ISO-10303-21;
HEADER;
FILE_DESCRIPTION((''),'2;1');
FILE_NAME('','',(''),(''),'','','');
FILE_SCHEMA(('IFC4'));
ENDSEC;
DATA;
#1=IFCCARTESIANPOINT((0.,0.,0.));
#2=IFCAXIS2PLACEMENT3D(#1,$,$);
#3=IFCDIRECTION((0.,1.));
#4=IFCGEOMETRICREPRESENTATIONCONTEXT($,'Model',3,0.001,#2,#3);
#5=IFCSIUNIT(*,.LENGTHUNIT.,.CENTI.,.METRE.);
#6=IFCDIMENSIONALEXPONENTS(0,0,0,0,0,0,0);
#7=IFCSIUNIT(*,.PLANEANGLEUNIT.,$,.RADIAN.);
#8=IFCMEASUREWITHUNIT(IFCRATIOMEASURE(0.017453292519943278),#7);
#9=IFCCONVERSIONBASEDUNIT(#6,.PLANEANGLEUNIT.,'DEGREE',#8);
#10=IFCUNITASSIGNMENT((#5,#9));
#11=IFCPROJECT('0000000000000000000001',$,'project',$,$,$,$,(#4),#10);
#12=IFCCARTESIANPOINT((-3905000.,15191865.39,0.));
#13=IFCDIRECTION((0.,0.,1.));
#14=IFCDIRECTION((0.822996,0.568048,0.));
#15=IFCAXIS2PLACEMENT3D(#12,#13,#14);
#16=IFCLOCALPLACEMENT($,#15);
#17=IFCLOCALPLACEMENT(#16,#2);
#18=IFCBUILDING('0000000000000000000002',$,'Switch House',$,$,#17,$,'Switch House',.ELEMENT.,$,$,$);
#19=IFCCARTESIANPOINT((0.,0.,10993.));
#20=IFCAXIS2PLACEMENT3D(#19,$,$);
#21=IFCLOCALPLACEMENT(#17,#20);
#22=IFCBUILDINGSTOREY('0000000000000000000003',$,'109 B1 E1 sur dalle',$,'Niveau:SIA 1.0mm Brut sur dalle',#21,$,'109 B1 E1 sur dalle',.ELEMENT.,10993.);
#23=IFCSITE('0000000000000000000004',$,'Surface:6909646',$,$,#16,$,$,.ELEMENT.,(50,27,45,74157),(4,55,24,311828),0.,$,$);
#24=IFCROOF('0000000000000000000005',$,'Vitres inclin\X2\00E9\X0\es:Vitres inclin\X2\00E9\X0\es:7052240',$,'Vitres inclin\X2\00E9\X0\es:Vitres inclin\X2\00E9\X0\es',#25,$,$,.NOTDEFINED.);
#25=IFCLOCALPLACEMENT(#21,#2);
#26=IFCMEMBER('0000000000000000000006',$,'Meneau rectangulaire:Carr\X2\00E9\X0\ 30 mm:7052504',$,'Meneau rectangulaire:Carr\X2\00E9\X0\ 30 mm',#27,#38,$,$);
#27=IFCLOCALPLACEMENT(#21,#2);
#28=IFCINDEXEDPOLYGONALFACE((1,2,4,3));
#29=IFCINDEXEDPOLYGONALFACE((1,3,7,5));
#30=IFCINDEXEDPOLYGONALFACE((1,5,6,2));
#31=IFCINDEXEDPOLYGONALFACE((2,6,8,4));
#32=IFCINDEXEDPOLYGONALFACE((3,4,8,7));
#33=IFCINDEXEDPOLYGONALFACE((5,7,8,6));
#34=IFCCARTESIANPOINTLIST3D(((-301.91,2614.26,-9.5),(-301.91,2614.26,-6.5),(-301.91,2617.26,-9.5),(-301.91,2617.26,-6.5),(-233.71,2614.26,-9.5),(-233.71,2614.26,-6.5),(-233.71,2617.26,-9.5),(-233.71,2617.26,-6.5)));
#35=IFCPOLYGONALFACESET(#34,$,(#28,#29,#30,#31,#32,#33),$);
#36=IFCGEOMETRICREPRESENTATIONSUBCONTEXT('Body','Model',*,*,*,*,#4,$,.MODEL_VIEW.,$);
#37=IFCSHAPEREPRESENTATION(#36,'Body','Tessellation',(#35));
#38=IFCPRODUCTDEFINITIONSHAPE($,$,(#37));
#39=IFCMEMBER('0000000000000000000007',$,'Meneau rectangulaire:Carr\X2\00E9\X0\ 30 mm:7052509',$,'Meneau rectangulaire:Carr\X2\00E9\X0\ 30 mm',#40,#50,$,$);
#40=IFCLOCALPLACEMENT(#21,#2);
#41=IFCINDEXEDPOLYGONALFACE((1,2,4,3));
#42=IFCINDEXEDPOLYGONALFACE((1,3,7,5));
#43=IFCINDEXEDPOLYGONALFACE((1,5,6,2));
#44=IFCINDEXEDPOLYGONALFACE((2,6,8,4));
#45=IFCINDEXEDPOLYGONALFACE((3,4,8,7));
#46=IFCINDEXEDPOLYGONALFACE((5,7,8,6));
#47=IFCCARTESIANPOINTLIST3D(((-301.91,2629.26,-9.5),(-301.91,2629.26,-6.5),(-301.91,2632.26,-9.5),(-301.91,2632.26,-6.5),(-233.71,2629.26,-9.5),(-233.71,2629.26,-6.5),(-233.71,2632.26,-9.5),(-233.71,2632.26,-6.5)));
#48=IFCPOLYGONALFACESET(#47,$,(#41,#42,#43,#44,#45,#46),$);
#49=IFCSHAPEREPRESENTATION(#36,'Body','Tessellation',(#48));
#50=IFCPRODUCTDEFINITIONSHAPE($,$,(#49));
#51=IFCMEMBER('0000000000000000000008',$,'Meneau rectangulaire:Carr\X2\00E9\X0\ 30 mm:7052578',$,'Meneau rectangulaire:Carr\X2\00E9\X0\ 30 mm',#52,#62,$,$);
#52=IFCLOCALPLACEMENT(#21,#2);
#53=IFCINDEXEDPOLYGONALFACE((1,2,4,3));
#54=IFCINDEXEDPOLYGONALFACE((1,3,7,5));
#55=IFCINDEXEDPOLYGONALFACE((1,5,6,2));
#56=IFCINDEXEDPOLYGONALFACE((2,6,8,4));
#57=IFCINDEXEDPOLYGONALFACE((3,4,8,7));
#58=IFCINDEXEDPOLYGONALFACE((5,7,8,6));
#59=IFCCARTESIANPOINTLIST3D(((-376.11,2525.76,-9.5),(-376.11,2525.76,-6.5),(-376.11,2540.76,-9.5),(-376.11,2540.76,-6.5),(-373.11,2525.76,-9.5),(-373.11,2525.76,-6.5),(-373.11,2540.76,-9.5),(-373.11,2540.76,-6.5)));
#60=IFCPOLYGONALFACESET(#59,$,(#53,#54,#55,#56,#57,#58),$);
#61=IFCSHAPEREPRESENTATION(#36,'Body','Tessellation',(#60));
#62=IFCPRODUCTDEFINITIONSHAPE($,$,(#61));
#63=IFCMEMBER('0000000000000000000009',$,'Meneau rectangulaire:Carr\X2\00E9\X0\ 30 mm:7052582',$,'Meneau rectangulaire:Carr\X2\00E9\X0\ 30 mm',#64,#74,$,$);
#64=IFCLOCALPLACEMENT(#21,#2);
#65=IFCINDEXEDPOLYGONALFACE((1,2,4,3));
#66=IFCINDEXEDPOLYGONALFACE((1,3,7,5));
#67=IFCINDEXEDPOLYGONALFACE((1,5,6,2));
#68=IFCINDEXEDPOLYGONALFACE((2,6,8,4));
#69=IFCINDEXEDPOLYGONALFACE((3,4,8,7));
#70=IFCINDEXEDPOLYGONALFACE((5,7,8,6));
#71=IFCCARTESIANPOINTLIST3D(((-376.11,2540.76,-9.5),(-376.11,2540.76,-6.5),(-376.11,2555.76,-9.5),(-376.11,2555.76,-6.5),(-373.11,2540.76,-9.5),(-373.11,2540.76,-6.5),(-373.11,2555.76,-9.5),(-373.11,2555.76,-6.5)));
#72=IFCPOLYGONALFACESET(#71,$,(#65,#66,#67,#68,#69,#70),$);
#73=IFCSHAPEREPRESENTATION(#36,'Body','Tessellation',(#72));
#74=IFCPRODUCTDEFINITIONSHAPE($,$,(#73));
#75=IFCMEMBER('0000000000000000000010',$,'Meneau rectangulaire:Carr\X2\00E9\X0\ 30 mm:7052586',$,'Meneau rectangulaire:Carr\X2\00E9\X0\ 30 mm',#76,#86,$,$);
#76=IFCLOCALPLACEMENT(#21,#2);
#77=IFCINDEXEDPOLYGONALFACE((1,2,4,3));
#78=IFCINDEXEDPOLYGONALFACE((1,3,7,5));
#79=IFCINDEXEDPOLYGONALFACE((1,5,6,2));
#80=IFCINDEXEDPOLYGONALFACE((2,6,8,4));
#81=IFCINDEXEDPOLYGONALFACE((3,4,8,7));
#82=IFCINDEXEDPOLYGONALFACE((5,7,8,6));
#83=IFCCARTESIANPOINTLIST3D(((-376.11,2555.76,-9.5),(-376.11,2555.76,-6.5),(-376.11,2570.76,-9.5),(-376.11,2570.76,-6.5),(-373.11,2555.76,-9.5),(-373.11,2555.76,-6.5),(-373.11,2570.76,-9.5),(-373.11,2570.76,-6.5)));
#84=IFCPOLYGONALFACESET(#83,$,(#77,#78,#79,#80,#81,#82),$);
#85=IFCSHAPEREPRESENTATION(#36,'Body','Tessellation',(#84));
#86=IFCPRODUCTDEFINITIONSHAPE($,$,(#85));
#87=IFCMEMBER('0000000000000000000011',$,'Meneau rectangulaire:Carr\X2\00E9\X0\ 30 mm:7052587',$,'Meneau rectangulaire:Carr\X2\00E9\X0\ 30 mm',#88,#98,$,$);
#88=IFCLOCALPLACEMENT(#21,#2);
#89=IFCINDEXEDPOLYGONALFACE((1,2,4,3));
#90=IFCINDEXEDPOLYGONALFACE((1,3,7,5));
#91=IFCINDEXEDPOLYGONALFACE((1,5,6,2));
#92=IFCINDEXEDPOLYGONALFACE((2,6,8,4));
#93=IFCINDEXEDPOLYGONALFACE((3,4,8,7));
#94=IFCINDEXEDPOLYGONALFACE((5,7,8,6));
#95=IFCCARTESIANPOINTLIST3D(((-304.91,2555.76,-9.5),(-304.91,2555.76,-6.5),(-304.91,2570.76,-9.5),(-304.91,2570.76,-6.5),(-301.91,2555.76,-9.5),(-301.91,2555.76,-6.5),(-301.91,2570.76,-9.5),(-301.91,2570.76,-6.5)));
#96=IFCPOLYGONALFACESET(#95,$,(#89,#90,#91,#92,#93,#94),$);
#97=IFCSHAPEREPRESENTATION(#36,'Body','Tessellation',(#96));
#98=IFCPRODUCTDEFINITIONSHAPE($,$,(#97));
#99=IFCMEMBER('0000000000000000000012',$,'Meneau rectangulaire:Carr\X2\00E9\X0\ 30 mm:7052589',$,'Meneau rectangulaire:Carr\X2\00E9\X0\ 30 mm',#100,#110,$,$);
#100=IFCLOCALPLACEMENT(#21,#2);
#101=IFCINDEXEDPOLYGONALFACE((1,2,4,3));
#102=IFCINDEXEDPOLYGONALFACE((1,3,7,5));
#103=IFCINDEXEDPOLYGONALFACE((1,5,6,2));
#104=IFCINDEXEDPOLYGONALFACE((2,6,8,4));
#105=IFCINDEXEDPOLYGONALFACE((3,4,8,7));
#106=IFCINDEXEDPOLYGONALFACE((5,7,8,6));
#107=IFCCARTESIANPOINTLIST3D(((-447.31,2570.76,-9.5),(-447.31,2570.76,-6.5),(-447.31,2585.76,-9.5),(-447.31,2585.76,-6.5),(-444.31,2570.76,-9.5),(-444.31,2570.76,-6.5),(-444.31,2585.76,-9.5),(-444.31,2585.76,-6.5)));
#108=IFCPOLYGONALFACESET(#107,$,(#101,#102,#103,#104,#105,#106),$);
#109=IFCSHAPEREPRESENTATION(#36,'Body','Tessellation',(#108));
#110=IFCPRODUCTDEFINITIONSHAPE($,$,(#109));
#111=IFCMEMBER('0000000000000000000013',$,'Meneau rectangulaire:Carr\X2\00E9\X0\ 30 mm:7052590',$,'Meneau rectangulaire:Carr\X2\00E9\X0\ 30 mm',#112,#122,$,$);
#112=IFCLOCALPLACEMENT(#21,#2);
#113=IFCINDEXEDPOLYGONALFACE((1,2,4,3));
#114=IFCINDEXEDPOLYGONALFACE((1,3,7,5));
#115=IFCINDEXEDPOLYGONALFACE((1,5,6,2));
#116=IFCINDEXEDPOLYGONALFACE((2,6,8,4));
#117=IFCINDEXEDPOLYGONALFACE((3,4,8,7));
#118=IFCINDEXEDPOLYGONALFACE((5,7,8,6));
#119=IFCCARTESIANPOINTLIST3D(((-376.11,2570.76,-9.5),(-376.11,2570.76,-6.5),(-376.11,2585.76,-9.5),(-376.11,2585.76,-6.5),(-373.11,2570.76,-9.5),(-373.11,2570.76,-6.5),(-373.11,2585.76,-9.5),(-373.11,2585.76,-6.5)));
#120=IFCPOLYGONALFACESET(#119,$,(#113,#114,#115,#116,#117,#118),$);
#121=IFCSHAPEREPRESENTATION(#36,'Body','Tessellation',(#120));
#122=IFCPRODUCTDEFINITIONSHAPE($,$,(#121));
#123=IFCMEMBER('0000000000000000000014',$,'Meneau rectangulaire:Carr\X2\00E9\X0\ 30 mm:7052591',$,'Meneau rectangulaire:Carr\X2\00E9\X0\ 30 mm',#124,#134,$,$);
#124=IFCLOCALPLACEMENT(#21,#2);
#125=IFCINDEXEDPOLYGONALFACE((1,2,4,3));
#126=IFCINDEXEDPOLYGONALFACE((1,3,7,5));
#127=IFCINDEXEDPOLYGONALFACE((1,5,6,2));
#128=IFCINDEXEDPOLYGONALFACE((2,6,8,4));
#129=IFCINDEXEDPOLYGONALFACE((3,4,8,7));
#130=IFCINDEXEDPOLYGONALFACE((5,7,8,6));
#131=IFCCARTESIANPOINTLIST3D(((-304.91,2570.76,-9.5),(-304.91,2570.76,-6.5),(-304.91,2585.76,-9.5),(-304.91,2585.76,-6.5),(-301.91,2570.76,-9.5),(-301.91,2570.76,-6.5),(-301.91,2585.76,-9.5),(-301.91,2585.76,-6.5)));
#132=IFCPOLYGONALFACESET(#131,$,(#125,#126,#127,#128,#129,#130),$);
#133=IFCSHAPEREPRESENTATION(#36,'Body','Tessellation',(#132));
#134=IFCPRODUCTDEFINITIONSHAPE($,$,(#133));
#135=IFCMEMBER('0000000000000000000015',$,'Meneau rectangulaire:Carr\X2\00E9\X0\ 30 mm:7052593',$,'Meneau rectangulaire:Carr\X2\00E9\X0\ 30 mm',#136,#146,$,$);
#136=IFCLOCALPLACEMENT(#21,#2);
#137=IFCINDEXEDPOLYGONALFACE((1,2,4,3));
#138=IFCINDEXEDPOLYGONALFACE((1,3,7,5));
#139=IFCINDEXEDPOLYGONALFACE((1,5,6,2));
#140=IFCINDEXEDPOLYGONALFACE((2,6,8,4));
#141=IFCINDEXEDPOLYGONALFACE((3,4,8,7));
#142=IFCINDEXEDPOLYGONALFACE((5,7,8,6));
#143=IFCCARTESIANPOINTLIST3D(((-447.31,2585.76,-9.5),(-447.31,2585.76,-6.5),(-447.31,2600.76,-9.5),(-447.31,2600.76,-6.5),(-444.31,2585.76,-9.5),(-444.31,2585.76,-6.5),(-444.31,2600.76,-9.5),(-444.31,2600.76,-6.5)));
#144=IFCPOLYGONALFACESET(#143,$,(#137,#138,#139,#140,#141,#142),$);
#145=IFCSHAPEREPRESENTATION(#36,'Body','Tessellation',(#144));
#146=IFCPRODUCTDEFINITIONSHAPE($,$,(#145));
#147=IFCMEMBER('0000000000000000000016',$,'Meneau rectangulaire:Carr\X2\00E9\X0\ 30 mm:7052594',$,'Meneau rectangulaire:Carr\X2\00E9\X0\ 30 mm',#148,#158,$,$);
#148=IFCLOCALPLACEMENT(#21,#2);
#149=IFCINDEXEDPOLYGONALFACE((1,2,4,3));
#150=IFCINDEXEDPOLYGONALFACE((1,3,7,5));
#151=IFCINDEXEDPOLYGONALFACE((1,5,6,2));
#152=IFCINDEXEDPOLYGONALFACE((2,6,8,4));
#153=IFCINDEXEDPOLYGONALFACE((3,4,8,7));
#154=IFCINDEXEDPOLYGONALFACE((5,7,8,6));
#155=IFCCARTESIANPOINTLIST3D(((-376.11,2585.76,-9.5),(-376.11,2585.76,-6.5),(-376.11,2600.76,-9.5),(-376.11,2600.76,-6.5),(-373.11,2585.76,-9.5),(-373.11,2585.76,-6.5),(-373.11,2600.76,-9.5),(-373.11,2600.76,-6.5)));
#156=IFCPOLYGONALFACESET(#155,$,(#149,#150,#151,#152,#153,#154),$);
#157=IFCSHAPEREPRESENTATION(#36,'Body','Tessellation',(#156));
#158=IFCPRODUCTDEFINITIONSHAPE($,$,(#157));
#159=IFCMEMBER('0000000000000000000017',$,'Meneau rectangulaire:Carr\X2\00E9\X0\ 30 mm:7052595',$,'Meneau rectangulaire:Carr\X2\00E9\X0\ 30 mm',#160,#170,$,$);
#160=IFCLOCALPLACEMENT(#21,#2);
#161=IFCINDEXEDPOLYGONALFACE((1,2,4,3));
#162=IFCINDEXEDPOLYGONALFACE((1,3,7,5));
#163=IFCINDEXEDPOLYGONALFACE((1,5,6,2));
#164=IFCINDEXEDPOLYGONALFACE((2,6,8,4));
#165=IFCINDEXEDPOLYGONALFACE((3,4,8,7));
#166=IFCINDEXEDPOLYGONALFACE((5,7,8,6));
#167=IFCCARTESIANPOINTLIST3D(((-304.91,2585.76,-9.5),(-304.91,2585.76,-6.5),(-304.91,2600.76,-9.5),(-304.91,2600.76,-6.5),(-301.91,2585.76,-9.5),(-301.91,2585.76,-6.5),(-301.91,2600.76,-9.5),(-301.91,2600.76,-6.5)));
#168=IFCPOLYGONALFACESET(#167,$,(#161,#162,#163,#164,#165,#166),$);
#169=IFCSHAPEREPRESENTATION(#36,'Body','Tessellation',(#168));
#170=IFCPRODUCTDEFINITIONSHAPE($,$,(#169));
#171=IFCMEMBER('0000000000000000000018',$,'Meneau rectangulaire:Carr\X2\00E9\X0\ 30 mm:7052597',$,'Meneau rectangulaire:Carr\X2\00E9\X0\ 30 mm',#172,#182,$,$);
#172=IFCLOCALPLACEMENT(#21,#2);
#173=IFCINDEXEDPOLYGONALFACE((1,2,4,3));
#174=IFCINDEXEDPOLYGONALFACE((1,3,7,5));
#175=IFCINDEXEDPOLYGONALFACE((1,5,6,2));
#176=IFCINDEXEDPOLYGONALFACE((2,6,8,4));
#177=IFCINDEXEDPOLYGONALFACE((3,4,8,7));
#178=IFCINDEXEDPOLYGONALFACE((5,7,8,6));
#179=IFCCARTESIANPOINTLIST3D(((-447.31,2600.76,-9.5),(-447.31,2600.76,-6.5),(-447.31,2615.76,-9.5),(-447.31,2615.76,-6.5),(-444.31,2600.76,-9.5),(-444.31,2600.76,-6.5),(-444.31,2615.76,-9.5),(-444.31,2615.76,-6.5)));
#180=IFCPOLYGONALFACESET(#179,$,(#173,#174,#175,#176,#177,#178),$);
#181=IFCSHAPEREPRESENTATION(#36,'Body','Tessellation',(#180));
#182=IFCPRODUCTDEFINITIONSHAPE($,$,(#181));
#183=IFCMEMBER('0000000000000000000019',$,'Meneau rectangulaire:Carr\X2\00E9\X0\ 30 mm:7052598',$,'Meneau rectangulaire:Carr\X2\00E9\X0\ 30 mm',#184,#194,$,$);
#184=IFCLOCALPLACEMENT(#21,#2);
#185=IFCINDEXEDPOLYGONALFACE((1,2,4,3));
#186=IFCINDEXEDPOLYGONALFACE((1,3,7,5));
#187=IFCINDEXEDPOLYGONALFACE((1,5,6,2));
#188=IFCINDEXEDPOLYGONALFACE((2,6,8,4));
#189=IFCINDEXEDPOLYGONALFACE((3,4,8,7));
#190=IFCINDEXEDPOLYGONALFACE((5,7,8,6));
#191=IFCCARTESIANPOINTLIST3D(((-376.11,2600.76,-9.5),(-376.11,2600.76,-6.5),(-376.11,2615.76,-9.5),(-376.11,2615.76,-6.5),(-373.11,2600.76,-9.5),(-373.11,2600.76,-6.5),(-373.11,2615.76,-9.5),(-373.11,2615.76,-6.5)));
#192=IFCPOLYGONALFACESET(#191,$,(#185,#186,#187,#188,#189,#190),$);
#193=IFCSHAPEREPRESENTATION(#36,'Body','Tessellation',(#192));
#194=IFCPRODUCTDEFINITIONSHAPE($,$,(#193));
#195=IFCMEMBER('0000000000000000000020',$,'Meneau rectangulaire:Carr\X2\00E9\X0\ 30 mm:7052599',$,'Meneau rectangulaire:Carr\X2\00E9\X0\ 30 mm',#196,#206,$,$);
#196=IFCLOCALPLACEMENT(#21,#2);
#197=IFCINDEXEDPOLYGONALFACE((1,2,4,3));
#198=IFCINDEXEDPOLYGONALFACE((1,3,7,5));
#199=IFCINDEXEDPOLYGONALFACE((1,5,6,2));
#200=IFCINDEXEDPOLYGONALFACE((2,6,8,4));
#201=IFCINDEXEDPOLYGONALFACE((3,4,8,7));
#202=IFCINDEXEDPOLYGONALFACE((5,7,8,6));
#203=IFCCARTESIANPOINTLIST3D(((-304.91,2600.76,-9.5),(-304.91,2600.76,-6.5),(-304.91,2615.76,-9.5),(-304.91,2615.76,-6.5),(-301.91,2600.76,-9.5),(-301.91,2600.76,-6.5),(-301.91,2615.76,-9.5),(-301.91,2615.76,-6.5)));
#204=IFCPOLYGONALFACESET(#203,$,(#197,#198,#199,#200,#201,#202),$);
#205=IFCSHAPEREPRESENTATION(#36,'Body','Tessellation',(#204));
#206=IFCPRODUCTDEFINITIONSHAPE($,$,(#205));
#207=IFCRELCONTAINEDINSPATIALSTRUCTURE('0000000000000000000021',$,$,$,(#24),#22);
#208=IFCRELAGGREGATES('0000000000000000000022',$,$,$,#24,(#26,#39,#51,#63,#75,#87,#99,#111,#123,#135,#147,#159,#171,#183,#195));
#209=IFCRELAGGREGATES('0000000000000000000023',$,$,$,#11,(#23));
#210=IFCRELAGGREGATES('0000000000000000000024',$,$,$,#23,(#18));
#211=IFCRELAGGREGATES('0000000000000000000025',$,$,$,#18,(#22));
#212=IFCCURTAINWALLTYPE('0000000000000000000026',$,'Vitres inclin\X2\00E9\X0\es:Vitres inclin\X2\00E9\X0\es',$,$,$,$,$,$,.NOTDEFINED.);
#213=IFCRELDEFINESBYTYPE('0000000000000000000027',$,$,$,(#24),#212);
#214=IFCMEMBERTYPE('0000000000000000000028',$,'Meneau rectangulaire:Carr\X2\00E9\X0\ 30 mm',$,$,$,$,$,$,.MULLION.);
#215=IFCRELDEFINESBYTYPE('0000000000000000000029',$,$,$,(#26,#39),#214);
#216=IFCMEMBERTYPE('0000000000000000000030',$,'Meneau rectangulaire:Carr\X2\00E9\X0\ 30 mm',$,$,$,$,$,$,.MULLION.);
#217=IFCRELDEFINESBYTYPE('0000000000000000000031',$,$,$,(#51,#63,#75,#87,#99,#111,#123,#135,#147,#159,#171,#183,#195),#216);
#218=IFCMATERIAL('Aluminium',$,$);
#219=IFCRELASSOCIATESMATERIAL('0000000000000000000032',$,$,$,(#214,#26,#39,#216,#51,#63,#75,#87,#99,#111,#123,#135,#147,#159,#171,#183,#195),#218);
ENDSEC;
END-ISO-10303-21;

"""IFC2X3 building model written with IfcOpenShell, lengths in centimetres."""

from ifc_helpers import new_model, entity, si_unit, converted_unit, direction, frame, origin, origin_2d_with_axis, place, context, subcontext, project, spatial, rectangle, extrude, source, transform, mapped, material, type_object, type_shapes, element, aggregate, save


model = new_model("IFC2X3")

# Units and contexts
model_context = context("Model", 3, precision=0.001, world=origin(), true_north=direction((0.0, 1.0)))
body_context = subcontext(model_context, "Body", "Model", "MODEL_VIEW")
ifc_project = project(units=[si_unit("LENGTHUNIT", "METRE", prefix="CENTI"), converted_unit("PLANEANGLEUNIT", "DEGREE", entity("IfcRatioMeasure", 0.017453292519943278), si_unit("PLANEANGLEUNIT", "RADIAN"), dimensions=[0, 0, 0, 0, 0, 0, 0])], contexts=[model_context])

# Site, building, storey
site_placement = place(None, frame((-3905000.0, 15191865.39, 0.0), z_axis=(0.0, 0.0, 1.0), x_axis=(0.822996, 0.568048, 0.0)))
site = spatial("IfcSite", under=ifc_project, at=site_placement, Name="Surface:6909646", CompositionType="ELEMENT", RefLatitude=(50, 27, 45, 74157), RefLongitude=(4, 55, 24, 311828), RefElevation=0.0)
building_placement = place(site_placement, origin())
building = spatial("IfcBuilding", under=site, at=building_placement, Name="Switch House", LongName="Switch House", CompositionType="ELEMENT")
storey_placement = place(building_placement, frame((0.0, 0.0, 10993.0)))
storey = spatial("IfcBuildingStorey", under=building, at=storey_placement, Name="109 B1 E1 sur dalle", ObjectType="Niveau:SIA 1.0mm Brut sur dalle", LongName="109 B1 E1 sur dalle", CompositionType="ELEMENT", Elevation=10993.0)

# Roof, members
curtain_wall_type = type_object("IfcCurtainWallType", Name="Vitres inclinées:Vitres inclinées", PredefinedType="NOTDEFINED")
roof_placement = place(storey_placement, frame((0.0, 0.0, -10993.0)))
roof = element("IfcRoof", 1, at=roof_placement, inside=storey, type_object=curtain_wall_type, Name="Vitres inclinées:Vitres inclinées:7052240", ObjectType="Vitres inclinées:Vitres inclinées", ShapeType="NOTDEFINED")
ifc_material = material(Name="Aluminium")
member_type_1 = type_object("IfcMemberType", Name="Meneau rectangulaire:Carré 30 mm", PredefinedType="MULLION", material=ifc_material)
shared_shape_1 = source(origin(), body_context, "Body", "SweptSolid", [
    extrude(rectangle(XDim=3.0, YDim=3.0, at=origin_2d_with_axis()), frame((0.0, 0.0, -68.2), z_axis=(0.0, 0.0, 1.0), x_axis=(0.0, -1.0, 0.0)), (0.0, 0.0, 1.0), 68.2),
])
type_shapes(member_type_1, [shared_shape_1])
member_1_placement = place(roof_placement, frame((-301.91, 2615.76, 10985.0), z_axis=(-1.0, 0.0, 0.0), x_axis=(0.0, 1.0, 0.0)))
member_1 = element("IfcMember", 2, at=member_1_placement, type_object=member_type_1, material=ifc_material, Name="Meneau rectangulaire:Carré 30 mm:7052504", ObjectType="Meneau rectangulaire:Carré 30 mm", context=body_context, shape_type="MappedRepresentation", body=[
    mapped(shared_shape_1, transform((0.0, 0.0, 0.0), scale=1.0)),
])
member_2_placement = place(roof_placement, frame((-301.91, 2630.76, 10985.0), z_axis=(-1.0, 0.0, 0.0), x_axis=(0.0, 1.0, 0.0)))
member_2 = element("IfcMember", 3, at=member_2_placement, type_object=member_type_1, material=ifc_material, Name="Meneau rectangulaire:Carré 30 mm:7052509", ObjectType="Meneau rectangulaire:Carré 30 mm", context=body_context, shape_type="MappedRepresentation", body=[
    mapped(shared_shape_1, transform((0.0, 0.0, 0.0), scale=1.0)),
])
member_type_2 = type_object("IfcMemberType", Name="Meneau rectangulaire:Carré 30 mm", PredefinedType="MULLION", material=ifc_material)
shared_shape_2 = source(origin(), body_context, "Body", "SweptSolid", [
    extrude(rectangle(XDim=3.0, YDim=3.0, at=origin_2d_with_axis()), frame((0.0, 0.0, -15.0), z_axis=(0.0, 0.0, 1.0), x_axis=(0.0, -1.0, 0.0)), (0.0, 0.0, 1.0), 15.0),
])
type_shapes(member_type_2, [shared_shape_2])
member_3_placement = place(roof_placement, frame((-374.61, 2540.76, 10985.0), z_axis=(0.0, 1.0, 0.0), x_axis=(1.0, 0.0, 0.0)))
member_3 = element("IfcMember", 4, at=member_3_placement, type_object=member_type_2, material=ifc_material, Name="Meneau rectangulaire:Carré 30 mm:7052578", ObjectType="Meneau rectangulaire:Carré 30 mm", context=body_context, shape_type="MappedRepresentation", body=[
    mapped(shared_shape_2, transform((0.0, 0.0, 0.0), scale=1.0)),
])
member_4_placement = place(roof_placement, frame((-374.61, 2555.76, 10985.0), z_axis=(0.0, 1.0, 0.0), x_axis=(1.0, 0.0, 0.0)))
member_4 = element("IfcMember", 5, at=member_4_placement, type_object=member_type_2, material=ifc_material, Name="Meneau rectangulaire:Carré 30 mm:7052582", ObjectType="Meneau rectangulaire:Carré 30 mm", context=body_context, shape_type="MappedRepresentation", body=[
    mapped(shared_shape_2, transform((0.0, 0.0, 0.0), scale=1.0)),
])
member_5_placement = place(roof_placement, frame((-374.61, 2570.76, 10985.0), z_axis=(0.0, 1.0, 0.0), x_axis=(1.0, 0.0, 0.0)))
member_5 = element("IfcMember", 6, at=member_5_placement, type_object=member_type_2, material=ifc_material, Name="Meneau rectangulaire:Carré 30 mm:7052586", ObjectType="Meneau rectangulaire:Carré 30 mm", context=body_context, shape_type="MappedRepresentation", body=[
    mapped(shared_shape_2, transform((0.0, 0.0, 0.0), scale=1.0)),
])
member_6_placement = place(roof_placement, frame((-303.41, 2570.76, 10985.0), z_axis=(0.0, 1.0, 0.0), x_axis=(1.0, 0.0, 0.0)))
member_6 = element("IfcMember", 7, at=member_6_placement, type_object=member_type_2, material=ifc_material, Name="Meneau rectangulaire:Carré 30 mm:7052587", ObjectType="Meneau rectangulaire:Carré 30 mm", context=body_context, shape_type="MappedRepresentation", body=[
    mapped(shared_shape_2, transform((0.0, 0.0, 0.0), scale=1.0)),
])
member_7_placement = place(roof_placement, frame((-445.81, 2585.76, 10985.0), z_axis=(0.0, 1.0, 0.0), x_axis=(1.0, 0.0, 0.0)))
member_7 = element("IfcMember", 8, at=member_7_placement, type_object=member_type_2, material=ifc_material, Name="Meneau rectangulaire:Carré 30 mm:7052589", ObjectType="Meneau rectangulaire:Carré 30 mm", context=body_context, shape_type="MappedRepresentation", body=[
    mapped(shared_shape_2, transform((0.0, 0.0, 0.0), scale=1.0)),
])
member_8_placement = place(roof_placement, frame((-374.61, 2585.76, 10985.0), z_axis=(0.0, 1.0, 0.0), x_axis=(1.0, 0.0, 0.0)))
member_8 = element("IfcMember", 9, at=member_8_placement, type_object=member_type_2, material=ifc_material, Name="Meneau rectangulaire:Carré 30 mm:7052590", ObjectType="Meneau rectangulaire:Carré 30 mm", context=body_context, shape_type="MappedRepresentation", body=[
    mapped(shared_shape_2, transform((0.0, 0.0, 0.0), scale=1.0)),
])
member_9_placement = place(roof_placement, frame((-303.41, 2585.76, 10985.0), z_axis=(0.0, 1.0, 0.0), x_axis=(1.0, 0.0, 0.0)))
member_9 = element("IfcMember", 10, at=member_9_placement, type_object=member_type_2, material=ifc_material, Name="Meneau rectangulaire:Carré 30 mm:7052591", ObjectType="Meneau rectangulaire:Carré 30 mm", context=body_context, shape_type="MappedRepresentation", body=[
    mapped(shared_shape_2, transform((0.0, 0.0, 0.0), scale=1.0)),
])
member_10_placement = place(roof_placement, frame((-445.81, 2600.76, 10985.0), z_axis=(0.0, 1.0, 0.0), x_axis=(1.0, 0.0, 0.0)))
member_10 = element("IfcMember", 11, at=member_10_placement, type_object=member_type_2, material=ifc_material, Name="Meneau rectangulaire:Carré 30 mm:7052593", ObjectType="Meneau rectangulaire:Carré 30 mm", context=body_context, shape_type="MappedRepresentation", body=[
    mapped(shared_shape_2, transform((0.0, 0.0, 0.0), scale=1.0)),
])
member_11_placement = place(roof_placement, frame((-374.61, 2600.76, 10985.0), z_axis=(0.0, 1.0, 0.0), x_axis=(1.0, 0.0, 0.0)))
member_11 = element("IfcMember", 12, at=member_11_placement, type_object=member_type_2, material=ifc_material, Name="Meneau rectangulaire:Carré 30 mm:7052594", ObjectType="Meneau rectangulaire:Carré 30 mm", context=body_context, shape_type="MappedRepresentation", body=[
    mapped(shared_shape_2, transform((0.0, 0.0, 0.0), scale=1.0)),
])
member_12_placement = place(roof_placement, frame((-303.41, 2600.76, 10985.0), z_axis=(0.0, 1.0, 0.0), x_axis=(1.0, 0.0, 0.0)))
member_12 = element("IfcMember", 13, at=member_12_placement, type_object=member_type_2, material=ifc_material, Name="Meneau rectangulaire:Carré 30 mm:7052595", ObjectType="Meneau rectangulaire:Carré 30 mm", context=body_context, shape_type="MappedRepresentation", body=[
    mapped(shared_shape_2, transform((0.0, 0.0, 0.0), scale=1.0)),
])
member_13_placement = place(roof_placement, frame((-445.81, 2615.76, 10985.0), z_axis=(0.0, 1.0, 0.0), x_axis=(1.0, 0.0, 0.0)))
member_13 = element("IfcMember", 14, at=member_13_placement, type_object=member_type_2, material=ifc_material, Name="Meneau rectangulaire:Carré 30 mm:7052597", ObjectType="Meneau rectangulaire:Carré 30 mm", context=body_context, shape_type="MappedRepresentation", body=[
    mapped(shared_shape_2, transform((0.0, 0.0, 0.0), scale=1.0)),
])
member_14_placement = place(roof_placement, frame((-374.61, 2615.76, 10985.0), z_axis=(0.0, 1.0, 0.0), x_axis=(1.0, 0.0, 0.0)))
member_14 = element("IfcMember", 15, at=member_14_placement, type_object=member_type_2, material=ifc_material, Name="Meneau rectangulaire:Carré 30 mm:7052598", ObjectType="Meneau rectangulaire:Carré 30 mm", context=body_context, shape_type="MappedRepresentation", body=[
    mapped(shared_shape_2, transform((0.0, 0.0, 0.0), scale=1.0)),
])
member_15_placement = place(roof_placement, frame((-303.41, 2615.76, 10985.0), z_axis=(0.0, 1.0, 0.0), x_axis=(1.0, 0.0, 0.0)))
member_15 = element("IfcMember", 16, at=member_15_placement, type_object=member_type_2, material=ifc_material, Name="Meneau rectangulaire:Carré 30 mm:7052599", ObjectType="Meneau rectangulaire:Carré 30 mm", context=body_context, shape_type="MappedRepresentation", body=[
    mapped(shared_shape_2, transform((0.0, 0.0, 0.0), scale=1.0)),
])
aggregate(roof, [member_1, member_2, member_3, member_4, member_5, member_6, member_7, member_8, member_9, member_10, member_11, member_12, member_13, member_14, member_15])

save(model, "model.ifc")
